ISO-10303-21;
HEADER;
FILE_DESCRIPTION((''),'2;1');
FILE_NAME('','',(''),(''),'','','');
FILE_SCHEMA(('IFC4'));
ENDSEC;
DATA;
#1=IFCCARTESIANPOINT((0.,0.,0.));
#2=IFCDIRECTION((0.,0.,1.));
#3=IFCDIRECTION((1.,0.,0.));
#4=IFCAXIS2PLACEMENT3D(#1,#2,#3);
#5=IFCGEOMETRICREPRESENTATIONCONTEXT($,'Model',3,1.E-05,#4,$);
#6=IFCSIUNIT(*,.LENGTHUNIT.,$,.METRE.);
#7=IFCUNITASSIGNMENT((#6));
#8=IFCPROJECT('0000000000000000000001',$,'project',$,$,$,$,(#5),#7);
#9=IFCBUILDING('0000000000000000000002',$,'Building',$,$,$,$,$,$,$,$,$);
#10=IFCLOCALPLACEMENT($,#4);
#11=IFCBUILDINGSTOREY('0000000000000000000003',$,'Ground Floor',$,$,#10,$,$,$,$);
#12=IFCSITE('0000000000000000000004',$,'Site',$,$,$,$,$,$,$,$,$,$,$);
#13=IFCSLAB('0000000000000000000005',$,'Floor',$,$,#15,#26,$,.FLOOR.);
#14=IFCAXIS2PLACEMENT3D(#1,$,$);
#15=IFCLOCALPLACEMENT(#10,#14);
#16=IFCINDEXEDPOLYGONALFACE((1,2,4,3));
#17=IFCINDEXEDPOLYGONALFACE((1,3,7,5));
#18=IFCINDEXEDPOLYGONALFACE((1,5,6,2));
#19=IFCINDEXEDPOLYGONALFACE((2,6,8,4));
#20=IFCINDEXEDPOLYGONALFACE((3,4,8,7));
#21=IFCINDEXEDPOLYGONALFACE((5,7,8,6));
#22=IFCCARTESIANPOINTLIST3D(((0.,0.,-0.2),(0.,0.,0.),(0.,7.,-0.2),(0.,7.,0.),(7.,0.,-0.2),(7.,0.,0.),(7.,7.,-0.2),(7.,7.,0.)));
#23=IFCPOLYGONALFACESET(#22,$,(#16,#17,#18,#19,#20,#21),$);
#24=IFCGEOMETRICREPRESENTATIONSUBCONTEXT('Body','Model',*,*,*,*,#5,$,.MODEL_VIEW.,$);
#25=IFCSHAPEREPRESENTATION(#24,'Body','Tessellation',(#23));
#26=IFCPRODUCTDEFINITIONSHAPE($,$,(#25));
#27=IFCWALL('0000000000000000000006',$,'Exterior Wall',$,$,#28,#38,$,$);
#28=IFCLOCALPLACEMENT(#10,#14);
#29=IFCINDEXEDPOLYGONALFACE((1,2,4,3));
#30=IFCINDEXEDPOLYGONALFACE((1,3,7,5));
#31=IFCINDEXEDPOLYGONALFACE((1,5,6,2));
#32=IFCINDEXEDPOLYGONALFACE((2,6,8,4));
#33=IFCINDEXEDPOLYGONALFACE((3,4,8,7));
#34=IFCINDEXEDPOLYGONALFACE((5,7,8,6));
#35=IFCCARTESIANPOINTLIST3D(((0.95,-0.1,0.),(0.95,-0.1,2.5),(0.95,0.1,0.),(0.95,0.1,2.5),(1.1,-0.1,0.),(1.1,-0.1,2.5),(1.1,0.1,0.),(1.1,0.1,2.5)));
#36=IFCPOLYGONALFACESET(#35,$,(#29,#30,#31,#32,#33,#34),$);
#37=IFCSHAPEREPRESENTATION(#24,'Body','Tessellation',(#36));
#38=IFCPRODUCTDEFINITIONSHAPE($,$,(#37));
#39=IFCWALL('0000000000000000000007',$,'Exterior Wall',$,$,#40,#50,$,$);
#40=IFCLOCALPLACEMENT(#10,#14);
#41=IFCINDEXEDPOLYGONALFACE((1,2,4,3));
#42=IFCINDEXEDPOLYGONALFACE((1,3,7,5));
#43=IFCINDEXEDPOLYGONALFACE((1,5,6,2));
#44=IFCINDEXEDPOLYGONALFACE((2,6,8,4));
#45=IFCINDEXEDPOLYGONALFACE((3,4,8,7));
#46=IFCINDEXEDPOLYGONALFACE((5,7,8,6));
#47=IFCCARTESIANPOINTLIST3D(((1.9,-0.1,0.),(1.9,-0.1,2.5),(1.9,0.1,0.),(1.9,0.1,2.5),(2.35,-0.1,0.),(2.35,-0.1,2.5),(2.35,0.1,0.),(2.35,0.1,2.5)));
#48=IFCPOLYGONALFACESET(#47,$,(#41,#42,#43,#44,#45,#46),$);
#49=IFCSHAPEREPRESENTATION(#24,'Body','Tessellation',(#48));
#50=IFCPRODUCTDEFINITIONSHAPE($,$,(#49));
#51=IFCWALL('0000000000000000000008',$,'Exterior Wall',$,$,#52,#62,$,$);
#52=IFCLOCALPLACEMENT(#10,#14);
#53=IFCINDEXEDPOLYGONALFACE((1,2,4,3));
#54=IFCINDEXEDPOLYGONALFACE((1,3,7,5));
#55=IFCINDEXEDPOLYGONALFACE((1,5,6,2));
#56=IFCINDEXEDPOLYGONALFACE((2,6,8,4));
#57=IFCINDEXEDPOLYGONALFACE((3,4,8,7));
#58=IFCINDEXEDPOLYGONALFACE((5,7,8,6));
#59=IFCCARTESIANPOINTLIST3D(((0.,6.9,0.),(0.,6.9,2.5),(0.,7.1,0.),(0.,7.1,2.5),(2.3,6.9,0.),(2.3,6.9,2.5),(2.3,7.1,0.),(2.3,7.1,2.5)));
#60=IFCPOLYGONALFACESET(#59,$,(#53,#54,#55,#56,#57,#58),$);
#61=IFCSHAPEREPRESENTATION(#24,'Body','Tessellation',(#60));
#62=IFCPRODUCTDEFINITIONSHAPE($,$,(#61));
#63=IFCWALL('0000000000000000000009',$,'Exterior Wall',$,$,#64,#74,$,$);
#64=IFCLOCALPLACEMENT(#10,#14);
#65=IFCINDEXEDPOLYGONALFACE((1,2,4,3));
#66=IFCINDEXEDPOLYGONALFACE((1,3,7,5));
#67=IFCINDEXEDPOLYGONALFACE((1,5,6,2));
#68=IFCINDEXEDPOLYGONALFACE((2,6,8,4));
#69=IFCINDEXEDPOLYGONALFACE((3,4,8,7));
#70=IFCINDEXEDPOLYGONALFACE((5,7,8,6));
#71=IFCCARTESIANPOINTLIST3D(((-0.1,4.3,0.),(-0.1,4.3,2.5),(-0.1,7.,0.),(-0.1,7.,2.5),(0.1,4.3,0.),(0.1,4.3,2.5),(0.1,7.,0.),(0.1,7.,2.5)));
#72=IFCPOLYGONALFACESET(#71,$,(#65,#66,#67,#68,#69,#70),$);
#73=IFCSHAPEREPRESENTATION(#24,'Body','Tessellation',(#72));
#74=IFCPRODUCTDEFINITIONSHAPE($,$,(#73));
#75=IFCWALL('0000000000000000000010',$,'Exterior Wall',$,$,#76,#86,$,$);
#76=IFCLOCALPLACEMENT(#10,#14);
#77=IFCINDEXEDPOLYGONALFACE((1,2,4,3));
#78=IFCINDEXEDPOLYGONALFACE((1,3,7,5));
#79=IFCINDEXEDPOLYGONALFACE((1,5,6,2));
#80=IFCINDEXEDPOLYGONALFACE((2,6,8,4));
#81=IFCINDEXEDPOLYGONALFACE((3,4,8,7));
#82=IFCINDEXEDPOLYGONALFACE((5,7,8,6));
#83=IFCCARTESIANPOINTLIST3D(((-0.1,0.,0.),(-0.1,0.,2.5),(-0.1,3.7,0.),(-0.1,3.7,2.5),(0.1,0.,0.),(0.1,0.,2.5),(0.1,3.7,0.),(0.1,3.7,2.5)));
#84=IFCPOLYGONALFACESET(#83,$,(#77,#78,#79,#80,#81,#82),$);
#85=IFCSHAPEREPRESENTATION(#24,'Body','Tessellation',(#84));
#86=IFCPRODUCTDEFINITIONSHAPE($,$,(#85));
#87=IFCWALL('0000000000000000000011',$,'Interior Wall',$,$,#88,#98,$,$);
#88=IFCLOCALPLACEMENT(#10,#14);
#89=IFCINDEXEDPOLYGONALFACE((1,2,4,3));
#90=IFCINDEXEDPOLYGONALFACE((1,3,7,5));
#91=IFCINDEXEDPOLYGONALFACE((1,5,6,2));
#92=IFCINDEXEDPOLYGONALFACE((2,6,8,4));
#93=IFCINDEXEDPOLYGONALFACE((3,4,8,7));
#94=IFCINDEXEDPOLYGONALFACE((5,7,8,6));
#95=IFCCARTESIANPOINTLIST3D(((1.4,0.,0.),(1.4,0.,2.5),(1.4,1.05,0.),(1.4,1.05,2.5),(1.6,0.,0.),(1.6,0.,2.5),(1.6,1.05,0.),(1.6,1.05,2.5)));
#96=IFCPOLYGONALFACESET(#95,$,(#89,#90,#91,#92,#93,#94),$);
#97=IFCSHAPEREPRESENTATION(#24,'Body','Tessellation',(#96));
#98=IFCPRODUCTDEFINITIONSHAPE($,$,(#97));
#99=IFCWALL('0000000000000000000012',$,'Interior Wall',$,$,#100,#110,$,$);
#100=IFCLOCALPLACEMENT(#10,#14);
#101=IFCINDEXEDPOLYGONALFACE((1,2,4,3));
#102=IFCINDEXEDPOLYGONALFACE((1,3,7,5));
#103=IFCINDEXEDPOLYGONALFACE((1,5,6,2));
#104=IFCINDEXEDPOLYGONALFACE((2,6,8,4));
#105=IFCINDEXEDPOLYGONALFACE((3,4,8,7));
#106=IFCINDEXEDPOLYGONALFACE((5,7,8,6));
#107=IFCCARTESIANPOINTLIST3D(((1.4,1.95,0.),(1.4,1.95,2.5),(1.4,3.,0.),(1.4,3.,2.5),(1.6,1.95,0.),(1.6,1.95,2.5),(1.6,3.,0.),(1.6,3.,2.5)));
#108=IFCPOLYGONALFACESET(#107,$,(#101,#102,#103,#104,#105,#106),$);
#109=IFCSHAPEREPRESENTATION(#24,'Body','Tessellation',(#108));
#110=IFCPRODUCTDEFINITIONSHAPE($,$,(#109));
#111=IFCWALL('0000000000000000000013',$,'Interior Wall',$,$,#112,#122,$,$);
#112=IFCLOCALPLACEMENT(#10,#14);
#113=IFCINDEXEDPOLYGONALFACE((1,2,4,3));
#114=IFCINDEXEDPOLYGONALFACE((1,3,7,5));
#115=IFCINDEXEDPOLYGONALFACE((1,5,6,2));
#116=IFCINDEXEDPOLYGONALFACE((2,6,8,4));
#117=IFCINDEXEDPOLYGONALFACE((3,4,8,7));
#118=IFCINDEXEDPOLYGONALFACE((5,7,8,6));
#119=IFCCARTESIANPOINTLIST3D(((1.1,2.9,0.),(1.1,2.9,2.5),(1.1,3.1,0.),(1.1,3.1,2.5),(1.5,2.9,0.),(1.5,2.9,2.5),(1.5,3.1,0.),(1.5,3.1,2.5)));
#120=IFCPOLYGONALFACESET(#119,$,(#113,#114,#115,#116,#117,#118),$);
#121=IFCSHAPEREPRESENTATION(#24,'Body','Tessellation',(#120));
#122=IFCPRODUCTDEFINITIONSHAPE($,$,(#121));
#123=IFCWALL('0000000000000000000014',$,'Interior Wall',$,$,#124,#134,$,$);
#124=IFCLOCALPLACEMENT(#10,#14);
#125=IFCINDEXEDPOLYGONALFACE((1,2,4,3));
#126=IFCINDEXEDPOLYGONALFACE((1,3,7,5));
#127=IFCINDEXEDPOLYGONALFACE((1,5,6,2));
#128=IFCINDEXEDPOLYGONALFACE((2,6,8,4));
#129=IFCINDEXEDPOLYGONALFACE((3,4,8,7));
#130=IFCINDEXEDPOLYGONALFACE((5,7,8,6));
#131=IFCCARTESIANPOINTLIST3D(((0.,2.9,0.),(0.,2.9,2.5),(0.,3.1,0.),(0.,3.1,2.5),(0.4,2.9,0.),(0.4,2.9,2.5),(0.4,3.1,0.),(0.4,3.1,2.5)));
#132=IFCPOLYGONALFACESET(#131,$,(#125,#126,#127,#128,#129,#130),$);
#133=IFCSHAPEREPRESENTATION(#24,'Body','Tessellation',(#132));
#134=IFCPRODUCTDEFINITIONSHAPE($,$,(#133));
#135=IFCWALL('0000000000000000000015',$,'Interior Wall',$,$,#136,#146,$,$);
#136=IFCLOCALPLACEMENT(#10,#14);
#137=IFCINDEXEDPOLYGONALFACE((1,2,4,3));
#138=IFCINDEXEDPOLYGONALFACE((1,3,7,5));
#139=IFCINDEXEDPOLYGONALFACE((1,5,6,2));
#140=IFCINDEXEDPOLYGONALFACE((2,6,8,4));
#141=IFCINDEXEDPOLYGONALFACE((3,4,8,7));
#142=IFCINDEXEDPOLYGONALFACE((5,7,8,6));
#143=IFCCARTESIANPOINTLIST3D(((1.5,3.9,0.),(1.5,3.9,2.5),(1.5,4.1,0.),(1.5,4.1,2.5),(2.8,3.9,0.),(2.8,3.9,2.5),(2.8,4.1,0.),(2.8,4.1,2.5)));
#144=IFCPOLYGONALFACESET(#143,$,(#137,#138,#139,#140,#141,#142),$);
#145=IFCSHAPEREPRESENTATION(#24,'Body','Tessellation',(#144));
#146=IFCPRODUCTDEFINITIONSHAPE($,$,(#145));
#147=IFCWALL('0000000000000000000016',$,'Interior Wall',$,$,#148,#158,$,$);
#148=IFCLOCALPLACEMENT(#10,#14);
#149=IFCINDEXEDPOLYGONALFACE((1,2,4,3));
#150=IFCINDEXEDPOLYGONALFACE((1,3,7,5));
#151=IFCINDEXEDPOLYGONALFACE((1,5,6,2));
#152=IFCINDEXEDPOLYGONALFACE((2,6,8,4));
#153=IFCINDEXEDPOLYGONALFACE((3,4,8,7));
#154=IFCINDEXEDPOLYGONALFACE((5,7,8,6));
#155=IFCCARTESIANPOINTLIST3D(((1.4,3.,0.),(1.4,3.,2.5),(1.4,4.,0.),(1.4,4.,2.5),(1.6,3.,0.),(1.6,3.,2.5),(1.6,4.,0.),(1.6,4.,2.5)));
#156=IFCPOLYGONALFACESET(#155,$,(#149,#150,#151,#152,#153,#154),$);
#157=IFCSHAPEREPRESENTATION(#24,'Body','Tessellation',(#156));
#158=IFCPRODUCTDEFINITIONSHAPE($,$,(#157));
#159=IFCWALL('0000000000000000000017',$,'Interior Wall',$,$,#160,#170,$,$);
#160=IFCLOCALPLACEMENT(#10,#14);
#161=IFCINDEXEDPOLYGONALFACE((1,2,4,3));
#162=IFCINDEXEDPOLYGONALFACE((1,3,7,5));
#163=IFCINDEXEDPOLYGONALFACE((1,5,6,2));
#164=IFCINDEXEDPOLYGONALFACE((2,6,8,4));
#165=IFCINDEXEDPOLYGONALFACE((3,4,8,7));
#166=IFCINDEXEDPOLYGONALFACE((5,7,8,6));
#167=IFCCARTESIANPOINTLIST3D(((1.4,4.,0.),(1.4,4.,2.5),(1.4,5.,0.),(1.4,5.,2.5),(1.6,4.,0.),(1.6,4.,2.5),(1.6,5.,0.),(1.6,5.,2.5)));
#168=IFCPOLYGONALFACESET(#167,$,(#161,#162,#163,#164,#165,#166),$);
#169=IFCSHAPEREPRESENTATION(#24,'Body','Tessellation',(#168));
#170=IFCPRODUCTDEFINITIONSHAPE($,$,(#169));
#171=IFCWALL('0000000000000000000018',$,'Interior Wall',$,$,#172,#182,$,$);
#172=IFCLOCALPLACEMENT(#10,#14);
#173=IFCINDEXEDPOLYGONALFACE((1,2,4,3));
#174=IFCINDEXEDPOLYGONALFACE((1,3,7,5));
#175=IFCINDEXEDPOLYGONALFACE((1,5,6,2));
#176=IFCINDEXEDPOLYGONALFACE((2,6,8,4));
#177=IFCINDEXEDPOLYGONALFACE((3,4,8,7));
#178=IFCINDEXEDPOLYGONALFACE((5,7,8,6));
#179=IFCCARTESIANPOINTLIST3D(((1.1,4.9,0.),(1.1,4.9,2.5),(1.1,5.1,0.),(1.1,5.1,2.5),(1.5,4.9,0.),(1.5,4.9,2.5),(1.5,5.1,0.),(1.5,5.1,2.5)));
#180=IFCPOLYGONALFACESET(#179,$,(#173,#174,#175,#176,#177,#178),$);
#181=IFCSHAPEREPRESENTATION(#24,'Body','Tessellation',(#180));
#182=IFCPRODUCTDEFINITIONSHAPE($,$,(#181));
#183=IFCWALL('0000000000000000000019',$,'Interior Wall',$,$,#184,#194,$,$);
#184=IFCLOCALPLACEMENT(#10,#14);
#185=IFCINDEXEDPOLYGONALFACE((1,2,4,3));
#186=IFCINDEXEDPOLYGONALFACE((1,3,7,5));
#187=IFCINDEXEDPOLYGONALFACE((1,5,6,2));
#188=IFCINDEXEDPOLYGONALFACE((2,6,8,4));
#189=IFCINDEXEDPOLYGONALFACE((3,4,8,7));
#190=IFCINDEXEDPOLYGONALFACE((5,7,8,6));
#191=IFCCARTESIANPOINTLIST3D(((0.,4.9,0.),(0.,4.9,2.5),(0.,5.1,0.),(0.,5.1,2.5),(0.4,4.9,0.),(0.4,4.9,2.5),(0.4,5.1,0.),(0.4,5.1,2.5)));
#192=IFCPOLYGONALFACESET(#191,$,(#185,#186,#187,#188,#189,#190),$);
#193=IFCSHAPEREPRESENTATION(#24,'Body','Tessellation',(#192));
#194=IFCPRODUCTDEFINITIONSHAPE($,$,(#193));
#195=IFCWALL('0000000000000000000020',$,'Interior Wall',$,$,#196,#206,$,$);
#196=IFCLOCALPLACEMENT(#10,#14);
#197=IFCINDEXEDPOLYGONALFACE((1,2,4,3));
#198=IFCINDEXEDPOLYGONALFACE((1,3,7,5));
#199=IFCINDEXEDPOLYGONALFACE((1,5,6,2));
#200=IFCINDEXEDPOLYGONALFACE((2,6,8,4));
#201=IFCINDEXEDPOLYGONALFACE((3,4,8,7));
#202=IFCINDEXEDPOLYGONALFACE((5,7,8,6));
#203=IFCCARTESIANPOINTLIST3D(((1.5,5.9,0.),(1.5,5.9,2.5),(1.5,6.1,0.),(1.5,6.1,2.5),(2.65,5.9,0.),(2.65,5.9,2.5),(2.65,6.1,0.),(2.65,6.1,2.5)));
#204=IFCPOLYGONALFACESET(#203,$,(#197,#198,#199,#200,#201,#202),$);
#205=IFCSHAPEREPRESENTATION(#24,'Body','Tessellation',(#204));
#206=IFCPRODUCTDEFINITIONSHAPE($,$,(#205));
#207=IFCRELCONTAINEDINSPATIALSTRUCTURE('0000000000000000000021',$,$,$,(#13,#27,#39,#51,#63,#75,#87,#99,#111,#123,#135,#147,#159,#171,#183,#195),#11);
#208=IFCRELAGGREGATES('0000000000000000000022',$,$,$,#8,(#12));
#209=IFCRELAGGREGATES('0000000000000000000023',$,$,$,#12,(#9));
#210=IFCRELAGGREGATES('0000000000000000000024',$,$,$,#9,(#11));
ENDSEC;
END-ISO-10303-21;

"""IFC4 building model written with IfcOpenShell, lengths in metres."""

from ifc_helpers import new_model, si_unit, frame, origin_with_axes, place, context, subcontext, project, spatial, indexed_curve, outline, extrude, element, save


model = new_model("IFC4")

# Units and contexts
model_context = context("Model", 3, precision=1e-05, world=origin_with_axes())
body_context = subcontext(model_context, "Body", "Model", "MODEL_VIEW")
ifc_project = project(units=[si_unit("LENGTHUNIT", "METRE")], contexts=[model_context])

# Site, building, storey
site = spatial("IfcSite", under=ifc_project, Name="Site")
building = spatial("IfcBuilding", under=site, Name="Building")
storey_placement = place(None, origin_with_axes())
storey = spatial("IfcBuildingStorey", under=building, at=storey_placement, Name="Ground Floor")

# Slab
slab_placement = place(storey_placement, frame((0.0, 0.0, -0.2), z_axis=(0.0, 0.0, 1.0), x_axis=(1.0, 0.0, 0.0)))
element("IfcSlab", 1, at=slab_placement, inside=storey, Name="Floor", PredefinedType="FLOOR", context=body_context, shape_type="SweptSolid", body=[
    extrude(outline(indexed_curve([(0.0, 0.0), (7.0, 0.0), (7.0, 7.0), (0.0, 7.0)])), None, (0.0, 0.0, 1.0), 0.2),
])

# Walls
wall_1_placement = place(storey_placement, frame((0.95, 0.0, 0.0), z_axis=(0.0, 0.0, 1.0), x_axis=(1.0, 0.0, 0.0)))
element("IfcWall", 2, at=wall_1_placement, inside=storey, Name="Exterior Wall", context=body_context, shape_type="SweptSolid", body=[
    extrude(outline(indexed_curve([(0.0, 0.0), (0.0, 0.2), (0.15, 0.2), (0.15, 0.0), (0.0, 0.0)], self_intersect=False)), frame((0.0, -0.1, 0.0), z_axis=(0.0, 0.0, 1.0), x_axis=(1.0, 0.0, 0.0)), (0.0, 0.0, 1.0), 2.5),
])
wall_2_placement = place(storey_placement, frame((1.9, 0.0, 0.0), z_axis=(0.0, 0.0, 1.0), x_axis=(1.0, 0.0, 0.0)))
element("IfcWall", 3, at=wall_2_placement, inside=storey, Name="Exterior Wall", context=body_context, shape_type="SweptSolid", body=[
    extrude(outline(indexed_curve([(0.0, 0.0), (0.0, 0.2), (0.45, 0.2), (0.45, 0.0), (0.0, 0.0)], self_intersect=False)), frame((0.0, -0.1, 0.0), z_axis=(0.0, 0.0, 1.0), x_axis=(1.0, 0.0, 0.0)), (0.0, 0.0, 1.0), 2.5),
])
wall_3_placement = place(storey_placement, frame((2.3, 7.0, 0.0), z_axis=(0.0, 0.0, 1.0), x_axis=(-1.0, 0.0, 0.0)))
element("IfcWall", 4, at=wall_3_placement, inside=storey, Name="Exterior Wall", context=body_context, shape_type="SweptSolid", body=[
    extrude(outline(indexed_curve([(0.0, 0.0), (0.0, 0.2), (2.3, 0.2), (2.3, 0.0), (0.0, 0.0)], self_intersect=False)), frame((0.0, -0.1, 0.0), z_axis=(0.0, 0.0, 1.0), x_axis=(1.0, 0.0, 0.0)), (0.0, 0.0, 1.0), 2.5),
])
wall_4_placement = place(storey_placement, frame((0.0, 7.0, 0.0), z_axis=(0.0, 0.0, 1.0), x_axis=(0.0, -1.0, 0.0)))
element("IfcWall", 5, at=wall_4_placement, inside=storey, Name="Exterior Wall", context=body_context, shape_type="SweptSolid", body=[
    extrude(outline(indexed_curve([(0.0, 0.0), (0.0, 0.2), (2.7, 0.2), (2.7, 0.0), (0.0, 0.0)], self_intersect=False)), frame((0.0, -0.1, 0.0), z_axis=(0.0, 0.0, 1.0), x_axis=(1.0, 0.0, 0.0)), (0.0, 0.0, 1.0), 2.5),
])
wall_5_placement = place(storey_placement, frame((0.0, 3.7, 0.0), z_axis=(0.0, 0.0, 1.0), x_axis=(0.0, -1.0, 0.0)))
element("IfcWall", 6, at=wall_5_placement, inside=storey, Name="Exterior Wall", context=body_context, shape_type="SweptSolid", body=[
    extrude(outline(indexed_curve([(0.0, 0.0), (0.0, 0.2), (3.7, 0.2), (3.7, 0.0), (0.0, 0.0)], self_intersect=False)), frame((0.0, -0.1, 0.0), z_axis=(0.0, 0.0, 1.0), x_axis=(1.0, 0.0, 0.0)), (0.0, 0.0, 1.0), 2.5),
])
for number, where, z_axis, x_axis, name in (
    (7, (1.5, 0.0, 0.0), (0.0, 0.0, 1.0), (0.0, 1.0, 0.0), "Interior Wall"),
    (8, (1.5, 1.95, 0.0), (0.0, 0.0, 1.0), (0.0, 1.0, 0.0), "Interior Wall"),
):
    element("IfcWall", number, at=place(storey_placement, frame(where, z_axis=z_axis, x_axis=x_axis)), inside=storey, Name=name, context=body_context, shape_type="SweptSolid", body=[
        extrude(outline(indexed_curve([(0.0, 0.0), (0.0, 0.2), (1.05, 0.2), (1.05, 0.0), (0.0, 0.0)], self_intersect=False)), frame((0.0, -0.1, 0.0), z_axis=(0.0, 0.0, 1.0), x_axis=(1.0, 0.0, 0.0)), (0.0, 0.0, 1.0), 2.5),
    ])
for number, where, z_axis, x_axis, name in (
    (9, (1.5, 3.0, 0.0), (0.0, 0.0, 1.0), (-1.0, 0.0, 0.0), "Interior Wall"),
    (10, (0.4, 3.0, 0.0), (0.0, 0.0, 1.0), (-1.0, 0.0, 0.0), "Interior Wall"),
):
    element("IfcWall", number, at=place(storey_placement, frame(where, z_axis=z_axis, x_axis=x_axis)), inside=storey, Name=name, context=body_context, shape_type="SweptSolid", body=[
        extrude(outline(indexed_curve([(0.0, 0.0), (0.0, 0.2), (0.4, 0.2), (0.4, 0.0), (0.0, 0.0)], self_intersect=False)), frame((0.0, -0.1, 0.0), z_axis=(0.0, 0.0, 1.0), x_axis=(1.0, 0.0, 0.0)), (0.0, 0.0, 1.0), 2.5),
    ])
wall_6_placement = place(storey_placement, frame((2.8, 4.0, 0.0), z_axis=(0.0, 0.0, 1.0), x_axis=(-1.0, 0.0, 0.0)))
element("IfcWall", 11, at=wall_6_placement, inside=storey, Name="Interior Wall", context=body_context, shape_type="SweptSolid", body=[
    extrude(outline(indexed_curve([(0.0, 0.0), (0.0, 0.2), (1.3, 0.2), (1.3, 0.0), (0.0, 0.0)], self_intersect=False)), frame((0.0, -0.1, 0.0), z_axis=(0.0, 0.0, 1.0), x_axis=(1.0, 0.0, 0.0)), (0.0, 0.0, 1.0), 2.5),
])
for number, where, z_axis, x_axis, name in (
    (12, (1.5, 4.0, 0.0), (0.0, 0.0, 1.0), (0.0, -1.0, 0.0), "Interior Wall"),
    (13, (1.5, 4.0, 0.0), (0.0, 0.0, 1.0), (0.0, 1.0, 0.0), "Interior Wall"),
):
    element("IfcWall", number, at=place(storey_placement, frame(where, z_axis=z_axis, x_axis=x_axis)), inside=storey, Name=name, context=body_context, shape_type="SweptSolid", body=[
        extrude(outline(indexed_curve([(0.0, 0.0), (0.0, 0.2), (1.0, 0.2), (1.0, 0.0), (0.0, 0.0)], self_intersect=False)), frame((0.0, -0.1, 0.0), z_axis=(0.0, 0.0, 1.0), x_axis=(1.0, 0.0, 0.0)), (0.0, 0.0, 1.0), 2.5),
    ])
for number, where, z_axis, x_axis, name in (
    (14, (1.5, 5.0, 0.0), (0.0, 0.0, 1.0), (-1.0, 0.0, 0.0), "Interior Wall"),
    (15, (0.4, 5.0, 0.0), (0.0, 0.0, 1.0), (-1.0, 0.0, 0.0), "Interior Wall"),
):
    element("IfcWall", number, at=place(storey_placement, frame(where, z_axis=z_axis, x_axis=x_axis)), inside=storey, Name=name, context=body_context, shape_type="SweptSolid", body=[
        extrude(outline(indexed_curve([(0.0, 0.0), (0.0, 0.2), (0.4, 0.2), (0.4, 0.0), (0.0, 0.0)], self_intersect=False)), frame((0.0, -0.1, 0.0), z_axis=(0.0, 0.0, 1.0), x_axis=(1.0, 0.0, 0.0)), (0.0, 0.0, 1.0), 2.5),
    ])
wall_7_placement = place(storey_placement, frame((2.65, 6.0, 0.0), z_axis=(0.0, 0.0, 1.0), x_axis=(-1.0, 0.0, 0.0)))
element("IfcWall", 16, at=wall_7_placement, inside=storey, Name="Interior Wall", context=body_context, shape_type="SweptSolid", body=[
    extrude(outline(indexed_curve([(0.0, 0.0), (0.0, 0.2), (1.15, 0.2), (1.15, 0.0), (0.0, 0.0)], self_intersect=False)), frame((0.0, -0.1, 0.0), z_axis=(0.0, 0.0, 1.0), x_axis=(1.0, 0.0, 0.0)), (0.0, 0.0, 1.0), 2.5),
])

save(model, "model.ifc")
